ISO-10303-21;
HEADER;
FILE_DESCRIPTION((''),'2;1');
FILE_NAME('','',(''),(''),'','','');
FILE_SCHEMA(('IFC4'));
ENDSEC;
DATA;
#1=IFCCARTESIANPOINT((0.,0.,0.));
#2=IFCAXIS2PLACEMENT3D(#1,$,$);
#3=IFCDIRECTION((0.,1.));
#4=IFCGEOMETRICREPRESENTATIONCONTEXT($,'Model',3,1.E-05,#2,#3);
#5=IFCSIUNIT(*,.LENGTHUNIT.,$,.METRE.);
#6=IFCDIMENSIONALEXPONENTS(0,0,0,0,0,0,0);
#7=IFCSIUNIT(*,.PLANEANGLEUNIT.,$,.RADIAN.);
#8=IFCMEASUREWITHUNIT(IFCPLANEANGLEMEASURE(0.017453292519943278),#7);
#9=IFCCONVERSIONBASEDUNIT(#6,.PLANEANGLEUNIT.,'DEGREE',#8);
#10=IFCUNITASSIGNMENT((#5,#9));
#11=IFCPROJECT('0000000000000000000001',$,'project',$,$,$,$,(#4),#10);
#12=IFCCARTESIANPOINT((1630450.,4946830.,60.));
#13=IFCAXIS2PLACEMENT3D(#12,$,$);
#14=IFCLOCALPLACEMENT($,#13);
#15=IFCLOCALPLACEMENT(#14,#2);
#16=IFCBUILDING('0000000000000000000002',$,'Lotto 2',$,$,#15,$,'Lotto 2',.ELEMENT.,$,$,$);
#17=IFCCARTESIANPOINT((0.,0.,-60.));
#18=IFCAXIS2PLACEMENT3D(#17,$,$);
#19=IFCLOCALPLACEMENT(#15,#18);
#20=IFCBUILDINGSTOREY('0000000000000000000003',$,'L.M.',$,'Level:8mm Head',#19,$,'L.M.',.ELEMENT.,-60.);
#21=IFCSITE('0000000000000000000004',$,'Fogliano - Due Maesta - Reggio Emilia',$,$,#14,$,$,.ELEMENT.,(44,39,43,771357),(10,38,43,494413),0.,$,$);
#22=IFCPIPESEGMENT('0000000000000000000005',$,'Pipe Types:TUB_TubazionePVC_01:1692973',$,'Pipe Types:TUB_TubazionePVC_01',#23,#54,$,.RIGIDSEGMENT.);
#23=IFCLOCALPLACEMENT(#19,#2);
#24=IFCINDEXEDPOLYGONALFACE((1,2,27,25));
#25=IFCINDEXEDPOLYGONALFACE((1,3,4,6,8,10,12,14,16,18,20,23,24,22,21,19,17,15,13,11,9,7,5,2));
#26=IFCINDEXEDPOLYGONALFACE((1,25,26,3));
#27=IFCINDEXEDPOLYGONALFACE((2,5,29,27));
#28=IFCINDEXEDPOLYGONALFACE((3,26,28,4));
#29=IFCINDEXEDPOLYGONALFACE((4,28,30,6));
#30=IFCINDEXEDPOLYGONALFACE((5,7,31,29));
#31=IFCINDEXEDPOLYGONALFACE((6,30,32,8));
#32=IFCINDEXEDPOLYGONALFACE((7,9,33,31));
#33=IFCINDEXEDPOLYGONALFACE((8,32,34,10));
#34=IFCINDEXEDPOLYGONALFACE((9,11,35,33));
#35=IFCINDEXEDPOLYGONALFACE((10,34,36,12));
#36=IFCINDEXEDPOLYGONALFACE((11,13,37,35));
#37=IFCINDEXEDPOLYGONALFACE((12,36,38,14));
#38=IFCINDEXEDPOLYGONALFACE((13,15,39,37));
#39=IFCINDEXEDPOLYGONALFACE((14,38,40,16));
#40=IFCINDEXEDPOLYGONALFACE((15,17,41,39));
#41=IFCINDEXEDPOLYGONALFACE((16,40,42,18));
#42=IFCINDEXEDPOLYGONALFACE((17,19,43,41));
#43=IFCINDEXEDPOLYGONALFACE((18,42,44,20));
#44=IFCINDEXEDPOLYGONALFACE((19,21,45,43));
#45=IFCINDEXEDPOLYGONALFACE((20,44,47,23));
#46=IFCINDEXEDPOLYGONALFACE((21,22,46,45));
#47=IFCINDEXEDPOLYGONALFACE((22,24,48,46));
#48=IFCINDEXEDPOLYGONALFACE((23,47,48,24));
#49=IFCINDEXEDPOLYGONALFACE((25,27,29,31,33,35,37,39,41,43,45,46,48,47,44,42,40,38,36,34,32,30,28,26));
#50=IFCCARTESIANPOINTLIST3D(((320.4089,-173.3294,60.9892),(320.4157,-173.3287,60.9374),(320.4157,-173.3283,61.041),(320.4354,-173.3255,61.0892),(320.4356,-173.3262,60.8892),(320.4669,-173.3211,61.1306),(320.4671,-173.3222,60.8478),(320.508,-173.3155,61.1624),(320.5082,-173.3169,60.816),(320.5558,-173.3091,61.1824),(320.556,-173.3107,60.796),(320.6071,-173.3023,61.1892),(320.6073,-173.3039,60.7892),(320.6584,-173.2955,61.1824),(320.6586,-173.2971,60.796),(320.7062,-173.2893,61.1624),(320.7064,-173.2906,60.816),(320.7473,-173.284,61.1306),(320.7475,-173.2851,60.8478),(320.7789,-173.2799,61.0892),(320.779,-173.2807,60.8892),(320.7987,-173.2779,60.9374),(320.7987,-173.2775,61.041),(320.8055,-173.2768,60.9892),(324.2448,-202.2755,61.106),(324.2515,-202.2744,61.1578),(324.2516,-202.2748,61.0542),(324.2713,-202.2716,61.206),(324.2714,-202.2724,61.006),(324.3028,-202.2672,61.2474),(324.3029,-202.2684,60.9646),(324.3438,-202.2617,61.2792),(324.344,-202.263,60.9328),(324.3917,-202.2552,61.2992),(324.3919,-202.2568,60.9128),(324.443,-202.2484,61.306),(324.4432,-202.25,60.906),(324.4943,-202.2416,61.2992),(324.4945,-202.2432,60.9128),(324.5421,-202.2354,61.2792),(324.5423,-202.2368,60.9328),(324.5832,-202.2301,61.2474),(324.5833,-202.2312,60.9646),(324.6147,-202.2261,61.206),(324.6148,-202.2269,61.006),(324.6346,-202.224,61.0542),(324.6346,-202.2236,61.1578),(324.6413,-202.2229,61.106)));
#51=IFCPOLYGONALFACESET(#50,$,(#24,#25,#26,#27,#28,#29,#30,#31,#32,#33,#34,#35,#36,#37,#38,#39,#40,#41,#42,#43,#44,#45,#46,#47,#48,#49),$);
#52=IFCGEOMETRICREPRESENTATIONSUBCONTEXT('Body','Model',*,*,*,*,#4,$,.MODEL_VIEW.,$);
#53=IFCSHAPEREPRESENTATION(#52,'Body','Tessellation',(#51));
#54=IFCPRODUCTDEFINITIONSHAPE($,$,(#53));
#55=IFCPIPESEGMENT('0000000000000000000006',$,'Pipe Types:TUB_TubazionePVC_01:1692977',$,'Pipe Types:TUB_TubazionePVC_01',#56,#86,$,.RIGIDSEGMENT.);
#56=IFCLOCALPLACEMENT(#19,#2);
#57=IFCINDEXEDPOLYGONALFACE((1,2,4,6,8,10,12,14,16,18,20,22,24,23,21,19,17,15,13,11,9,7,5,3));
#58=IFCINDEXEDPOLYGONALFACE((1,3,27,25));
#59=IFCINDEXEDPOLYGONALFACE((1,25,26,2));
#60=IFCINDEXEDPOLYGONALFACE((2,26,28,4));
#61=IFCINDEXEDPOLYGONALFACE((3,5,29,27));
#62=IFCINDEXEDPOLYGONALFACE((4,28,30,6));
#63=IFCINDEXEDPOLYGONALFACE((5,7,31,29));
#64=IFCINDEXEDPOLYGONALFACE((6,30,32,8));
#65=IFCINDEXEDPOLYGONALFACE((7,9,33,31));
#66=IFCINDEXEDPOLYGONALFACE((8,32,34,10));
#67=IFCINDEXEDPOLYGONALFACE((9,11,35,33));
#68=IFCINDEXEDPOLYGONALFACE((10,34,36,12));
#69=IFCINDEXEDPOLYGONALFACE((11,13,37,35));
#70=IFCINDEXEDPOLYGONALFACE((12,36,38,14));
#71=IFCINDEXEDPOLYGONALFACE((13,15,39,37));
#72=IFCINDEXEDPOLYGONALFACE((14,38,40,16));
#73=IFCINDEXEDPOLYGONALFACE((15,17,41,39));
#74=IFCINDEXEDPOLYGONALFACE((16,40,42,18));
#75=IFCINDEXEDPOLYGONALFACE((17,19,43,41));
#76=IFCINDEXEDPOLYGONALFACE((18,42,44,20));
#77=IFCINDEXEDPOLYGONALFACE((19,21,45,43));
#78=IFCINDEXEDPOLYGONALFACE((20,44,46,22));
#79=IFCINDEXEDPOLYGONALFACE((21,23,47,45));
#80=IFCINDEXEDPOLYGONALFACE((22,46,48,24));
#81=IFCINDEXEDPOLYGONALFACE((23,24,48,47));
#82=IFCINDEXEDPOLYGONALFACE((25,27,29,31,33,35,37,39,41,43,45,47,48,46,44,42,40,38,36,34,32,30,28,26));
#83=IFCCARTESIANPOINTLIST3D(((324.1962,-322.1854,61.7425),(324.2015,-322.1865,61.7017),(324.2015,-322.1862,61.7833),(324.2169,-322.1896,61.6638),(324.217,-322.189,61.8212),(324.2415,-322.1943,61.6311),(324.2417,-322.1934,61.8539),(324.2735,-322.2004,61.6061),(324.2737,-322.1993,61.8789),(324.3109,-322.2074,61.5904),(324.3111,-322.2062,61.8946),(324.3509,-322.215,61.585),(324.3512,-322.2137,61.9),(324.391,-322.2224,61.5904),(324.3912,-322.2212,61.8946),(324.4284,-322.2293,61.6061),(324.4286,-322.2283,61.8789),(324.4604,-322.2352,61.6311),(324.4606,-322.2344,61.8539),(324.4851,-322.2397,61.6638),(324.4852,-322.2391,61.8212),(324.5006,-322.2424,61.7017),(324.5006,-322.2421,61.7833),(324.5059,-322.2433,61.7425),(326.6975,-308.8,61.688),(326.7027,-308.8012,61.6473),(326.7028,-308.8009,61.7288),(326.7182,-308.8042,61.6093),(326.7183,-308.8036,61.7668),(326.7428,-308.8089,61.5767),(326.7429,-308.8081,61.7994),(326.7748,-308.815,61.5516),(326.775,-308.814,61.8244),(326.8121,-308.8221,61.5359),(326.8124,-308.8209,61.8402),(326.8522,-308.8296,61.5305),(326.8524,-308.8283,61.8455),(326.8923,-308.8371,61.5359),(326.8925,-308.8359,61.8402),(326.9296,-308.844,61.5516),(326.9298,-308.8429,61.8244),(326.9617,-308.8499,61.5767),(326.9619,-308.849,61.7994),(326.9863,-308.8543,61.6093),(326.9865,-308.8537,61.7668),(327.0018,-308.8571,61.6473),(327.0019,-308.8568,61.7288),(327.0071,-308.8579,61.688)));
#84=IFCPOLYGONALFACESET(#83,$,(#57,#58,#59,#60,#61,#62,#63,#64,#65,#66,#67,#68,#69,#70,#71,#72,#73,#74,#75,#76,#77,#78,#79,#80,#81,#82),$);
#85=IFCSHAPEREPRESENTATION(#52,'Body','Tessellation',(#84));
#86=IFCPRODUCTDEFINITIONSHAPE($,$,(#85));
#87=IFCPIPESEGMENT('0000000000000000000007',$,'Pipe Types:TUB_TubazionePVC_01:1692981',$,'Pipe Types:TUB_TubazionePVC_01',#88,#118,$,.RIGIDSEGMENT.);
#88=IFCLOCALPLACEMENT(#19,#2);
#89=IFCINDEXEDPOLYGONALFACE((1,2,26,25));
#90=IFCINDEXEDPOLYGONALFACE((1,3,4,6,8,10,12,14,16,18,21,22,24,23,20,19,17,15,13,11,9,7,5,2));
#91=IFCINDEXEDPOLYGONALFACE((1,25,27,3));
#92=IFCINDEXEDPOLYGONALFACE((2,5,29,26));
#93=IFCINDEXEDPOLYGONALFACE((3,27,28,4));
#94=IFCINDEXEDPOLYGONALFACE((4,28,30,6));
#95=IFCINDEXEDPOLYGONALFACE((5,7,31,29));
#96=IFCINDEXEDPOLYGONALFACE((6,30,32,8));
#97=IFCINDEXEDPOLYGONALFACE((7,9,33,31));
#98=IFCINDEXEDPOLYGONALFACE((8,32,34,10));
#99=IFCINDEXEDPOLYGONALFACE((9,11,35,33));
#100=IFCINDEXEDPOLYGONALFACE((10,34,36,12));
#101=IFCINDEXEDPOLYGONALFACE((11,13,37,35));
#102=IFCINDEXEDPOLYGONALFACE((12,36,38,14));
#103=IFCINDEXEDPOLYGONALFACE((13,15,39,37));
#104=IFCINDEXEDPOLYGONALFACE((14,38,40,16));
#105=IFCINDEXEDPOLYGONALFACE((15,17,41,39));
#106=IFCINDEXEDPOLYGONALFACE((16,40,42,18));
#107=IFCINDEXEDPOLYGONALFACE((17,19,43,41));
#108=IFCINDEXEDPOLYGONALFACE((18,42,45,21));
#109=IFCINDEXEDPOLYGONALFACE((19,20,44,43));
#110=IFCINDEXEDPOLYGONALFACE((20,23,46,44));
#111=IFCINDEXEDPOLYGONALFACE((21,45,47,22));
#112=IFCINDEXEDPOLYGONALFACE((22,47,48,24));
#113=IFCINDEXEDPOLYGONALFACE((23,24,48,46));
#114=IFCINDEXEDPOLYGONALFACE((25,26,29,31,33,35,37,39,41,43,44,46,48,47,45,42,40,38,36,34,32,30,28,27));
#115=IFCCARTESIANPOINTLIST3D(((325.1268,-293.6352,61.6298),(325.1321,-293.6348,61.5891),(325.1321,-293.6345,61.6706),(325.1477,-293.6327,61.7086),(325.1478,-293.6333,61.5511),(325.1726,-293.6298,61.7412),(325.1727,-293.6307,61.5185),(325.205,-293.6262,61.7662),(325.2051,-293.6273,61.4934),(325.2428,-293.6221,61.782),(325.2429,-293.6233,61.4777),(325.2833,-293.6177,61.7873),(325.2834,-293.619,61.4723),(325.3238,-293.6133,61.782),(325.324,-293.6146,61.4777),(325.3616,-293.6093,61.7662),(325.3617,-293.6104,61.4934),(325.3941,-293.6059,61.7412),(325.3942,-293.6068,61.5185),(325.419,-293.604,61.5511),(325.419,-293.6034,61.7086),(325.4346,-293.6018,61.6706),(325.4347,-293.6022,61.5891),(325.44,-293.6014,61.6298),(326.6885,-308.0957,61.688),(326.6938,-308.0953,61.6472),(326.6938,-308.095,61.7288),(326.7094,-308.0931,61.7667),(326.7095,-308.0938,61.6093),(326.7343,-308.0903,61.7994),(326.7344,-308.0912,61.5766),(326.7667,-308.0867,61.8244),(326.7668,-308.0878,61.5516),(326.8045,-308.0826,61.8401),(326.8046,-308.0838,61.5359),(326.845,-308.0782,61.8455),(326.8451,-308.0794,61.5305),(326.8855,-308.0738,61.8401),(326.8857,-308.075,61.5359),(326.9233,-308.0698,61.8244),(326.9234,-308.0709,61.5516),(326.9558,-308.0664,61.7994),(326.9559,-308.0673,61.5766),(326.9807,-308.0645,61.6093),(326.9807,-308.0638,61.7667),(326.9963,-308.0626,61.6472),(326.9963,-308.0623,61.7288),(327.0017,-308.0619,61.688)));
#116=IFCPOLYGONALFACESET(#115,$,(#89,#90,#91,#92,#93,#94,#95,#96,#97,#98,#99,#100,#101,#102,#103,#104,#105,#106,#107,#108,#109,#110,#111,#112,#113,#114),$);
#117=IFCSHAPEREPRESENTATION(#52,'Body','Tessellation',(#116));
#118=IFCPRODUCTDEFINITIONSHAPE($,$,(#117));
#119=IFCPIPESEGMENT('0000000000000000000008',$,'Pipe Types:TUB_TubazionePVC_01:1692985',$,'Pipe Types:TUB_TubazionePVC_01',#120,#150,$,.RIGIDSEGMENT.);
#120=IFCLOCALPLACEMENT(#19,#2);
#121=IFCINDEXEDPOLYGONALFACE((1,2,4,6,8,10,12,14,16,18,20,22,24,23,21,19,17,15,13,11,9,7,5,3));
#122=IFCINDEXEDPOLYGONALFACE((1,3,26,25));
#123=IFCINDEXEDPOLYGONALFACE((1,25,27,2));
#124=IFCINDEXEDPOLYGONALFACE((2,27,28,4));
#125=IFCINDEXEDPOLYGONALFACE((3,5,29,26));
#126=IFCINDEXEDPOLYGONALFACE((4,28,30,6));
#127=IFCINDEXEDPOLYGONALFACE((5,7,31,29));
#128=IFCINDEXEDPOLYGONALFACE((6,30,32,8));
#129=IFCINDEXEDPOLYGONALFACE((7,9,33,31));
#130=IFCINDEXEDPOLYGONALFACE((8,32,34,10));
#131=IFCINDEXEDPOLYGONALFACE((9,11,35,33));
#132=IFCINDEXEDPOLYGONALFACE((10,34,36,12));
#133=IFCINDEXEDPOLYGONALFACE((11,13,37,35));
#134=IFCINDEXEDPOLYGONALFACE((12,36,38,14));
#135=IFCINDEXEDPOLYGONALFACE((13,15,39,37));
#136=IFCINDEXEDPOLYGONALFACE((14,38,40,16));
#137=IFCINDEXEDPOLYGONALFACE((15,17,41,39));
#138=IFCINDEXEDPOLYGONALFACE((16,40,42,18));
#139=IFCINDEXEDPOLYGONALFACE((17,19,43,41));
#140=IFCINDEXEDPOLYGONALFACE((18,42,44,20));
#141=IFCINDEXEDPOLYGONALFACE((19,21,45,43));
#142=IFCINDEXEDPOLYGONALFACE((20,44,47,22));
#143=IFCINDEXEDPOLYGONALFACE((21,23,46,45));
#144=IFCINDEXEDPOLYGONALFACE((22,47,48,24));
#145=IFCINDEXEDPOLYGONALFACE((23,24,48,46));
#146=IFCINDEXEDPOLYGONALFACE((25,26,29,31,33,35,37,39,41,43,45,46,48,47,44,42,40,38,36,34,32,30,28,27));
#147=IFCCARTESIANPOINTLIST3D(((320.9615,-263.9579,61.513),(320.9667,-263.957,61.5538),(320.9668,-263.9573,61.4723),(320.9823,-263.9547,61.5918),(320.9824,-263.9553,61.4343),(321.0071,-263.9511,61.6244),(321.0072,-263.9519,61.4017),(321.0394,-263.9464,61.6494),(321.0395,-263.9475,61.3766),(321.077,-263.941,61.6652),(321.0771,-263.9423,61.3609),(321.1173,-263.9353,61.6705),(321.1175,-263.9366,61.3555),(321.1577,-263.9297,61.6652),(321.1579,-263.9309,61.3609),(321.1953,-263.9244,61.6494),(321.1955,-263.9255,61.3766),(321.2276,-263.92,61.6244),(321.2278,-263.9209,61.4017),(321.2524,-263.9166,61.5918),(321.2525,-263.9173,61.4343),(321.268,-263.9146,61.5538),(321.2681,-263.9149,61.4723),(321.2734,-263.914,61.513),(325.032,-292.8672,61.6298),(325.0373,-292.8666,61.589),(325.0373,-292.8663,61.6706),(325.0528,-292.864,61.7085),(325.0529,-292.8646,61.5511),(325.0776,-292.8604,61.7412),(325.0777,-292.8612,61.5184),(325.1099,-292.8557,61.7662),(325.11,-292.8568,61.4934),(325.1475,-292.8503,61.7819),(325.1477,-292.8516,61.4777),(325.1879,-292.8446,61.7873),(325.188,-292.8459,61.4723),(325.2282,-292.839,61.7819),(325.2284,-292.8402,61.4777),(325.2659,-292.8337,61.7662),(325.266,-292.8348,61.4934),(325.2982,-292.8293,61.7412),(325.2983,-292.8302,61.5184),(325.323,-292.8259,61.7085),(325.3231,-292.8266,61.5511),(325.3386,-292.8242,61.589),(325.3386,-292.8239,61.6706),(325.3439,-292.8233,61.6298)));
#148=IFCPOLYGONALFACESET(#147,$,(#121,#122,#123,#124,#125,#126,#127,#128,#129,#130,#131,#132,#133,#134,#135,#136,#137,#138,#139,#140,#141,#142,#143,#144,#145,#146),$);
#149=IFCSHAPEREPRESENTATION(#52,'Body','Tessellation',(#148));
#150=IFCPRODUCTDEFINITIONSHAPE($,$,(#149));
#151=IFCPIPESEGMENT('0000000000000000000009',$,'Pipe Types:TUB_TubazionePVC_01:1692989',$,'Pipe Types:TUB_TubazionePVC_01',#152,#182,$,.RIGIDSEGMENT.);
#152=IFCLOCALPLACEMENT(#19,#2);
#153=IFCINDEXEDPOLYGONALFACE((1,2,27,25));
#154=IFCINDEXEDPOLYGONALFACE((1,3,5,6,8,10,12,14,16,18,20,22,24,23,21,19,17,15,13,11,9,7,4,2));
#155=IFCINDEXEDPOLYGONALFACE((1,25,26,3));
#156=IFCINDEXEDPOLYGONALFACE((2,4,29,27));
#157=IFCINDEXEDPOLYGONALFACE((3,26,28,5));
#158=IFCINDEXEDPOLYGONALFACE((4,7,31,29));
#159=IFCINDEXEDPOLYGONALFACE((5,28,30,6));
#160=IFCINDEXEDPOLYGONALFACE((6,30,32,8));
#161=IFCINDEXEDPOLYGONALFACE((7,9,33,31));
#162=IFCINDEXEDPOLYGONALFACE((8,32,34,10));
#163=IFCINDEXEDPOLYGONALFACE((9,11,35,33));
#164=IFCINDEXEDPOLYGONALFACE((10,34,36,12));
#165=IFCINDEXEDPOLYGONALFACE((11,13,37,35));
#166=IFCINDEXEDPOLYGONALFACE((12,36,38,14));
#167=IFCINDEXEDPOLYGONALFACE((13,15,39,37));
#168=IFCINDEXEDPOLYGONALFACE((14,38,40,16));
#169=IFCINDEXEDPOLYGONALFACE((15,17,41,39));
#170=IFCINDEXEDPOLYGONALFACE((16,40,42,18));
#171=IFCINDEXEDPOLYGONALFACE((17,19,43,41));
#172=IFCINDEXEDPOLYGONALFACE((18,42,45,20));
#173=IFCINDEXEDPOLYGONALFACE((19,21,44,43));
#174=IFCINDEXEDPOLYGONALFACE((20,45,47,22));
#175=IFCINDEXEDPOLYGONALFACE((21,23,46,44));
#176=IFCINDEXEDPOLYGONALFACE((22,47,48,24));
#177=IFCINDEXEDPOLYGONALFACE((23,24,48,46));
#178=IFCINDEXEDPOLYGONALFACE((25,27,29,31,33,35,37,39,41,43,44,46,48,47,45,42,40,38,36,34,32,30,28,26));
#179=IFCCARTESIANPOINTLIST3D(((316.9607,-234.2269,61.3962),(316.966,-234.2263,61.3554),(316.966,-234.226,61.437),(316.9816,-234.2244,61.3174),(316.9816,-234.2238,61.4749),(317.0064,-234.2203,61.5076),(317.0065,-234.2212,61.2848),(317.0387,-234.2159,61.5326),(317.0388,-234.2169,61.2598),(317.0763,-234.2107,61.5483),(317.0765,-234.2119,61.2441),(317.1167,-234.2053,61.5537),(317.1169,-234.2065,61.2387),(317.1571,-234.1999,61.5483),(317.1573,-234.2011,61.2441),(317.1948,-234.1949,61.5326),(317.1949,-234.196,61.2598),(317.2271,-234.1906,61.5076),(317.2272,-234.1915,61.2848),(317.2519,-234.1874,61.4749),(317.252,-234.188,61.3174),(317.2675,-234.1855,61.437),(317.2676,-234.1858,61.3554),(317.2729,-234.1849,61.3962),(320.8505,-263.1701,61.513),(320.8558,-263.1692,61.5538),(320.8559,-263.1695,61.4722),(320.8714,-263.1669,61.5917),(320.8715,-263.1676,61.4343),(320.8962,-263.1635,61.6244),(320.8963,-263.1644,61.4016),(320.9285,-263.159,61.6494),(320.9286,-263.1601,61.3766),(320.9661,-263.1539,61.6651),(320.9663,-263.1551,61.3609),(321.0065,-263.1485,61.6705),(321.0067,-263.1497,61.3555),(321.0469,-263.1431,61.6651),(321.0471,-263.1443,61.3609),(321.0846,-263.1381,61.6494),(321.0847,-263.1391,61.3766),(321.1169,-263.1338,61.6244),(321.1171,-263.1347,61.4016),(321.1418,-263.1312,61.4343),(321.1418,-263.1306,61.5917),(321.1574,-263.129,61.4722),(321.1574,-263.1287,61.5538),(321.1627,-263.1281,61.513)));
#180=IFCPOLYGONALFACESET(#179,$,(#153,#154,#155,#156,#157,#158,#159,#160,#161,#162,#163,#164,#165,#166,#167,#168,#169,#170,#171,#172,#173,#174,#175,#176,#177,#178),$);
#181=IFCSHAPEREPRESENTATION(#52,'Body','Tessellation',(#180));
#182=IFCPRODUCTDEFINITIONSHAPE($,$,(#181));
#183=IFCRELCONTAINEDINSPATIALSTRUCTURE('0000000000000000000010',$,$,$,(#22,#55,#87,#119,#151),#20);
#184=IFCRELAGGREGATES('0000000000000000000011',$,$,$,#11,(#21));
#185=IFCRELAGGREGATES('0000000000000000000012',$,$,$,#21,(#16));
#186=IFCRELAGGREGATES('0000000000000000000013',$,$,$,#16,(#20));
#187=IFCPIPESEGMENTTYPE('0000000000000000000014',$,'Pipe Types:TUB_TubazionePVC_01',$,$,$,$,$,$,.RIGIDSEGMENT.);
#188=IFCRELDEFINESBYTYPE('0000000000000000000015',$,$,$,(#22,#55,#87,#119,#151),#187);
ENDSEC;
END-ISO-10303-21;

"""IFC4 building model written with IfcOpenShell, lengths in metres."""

from ifc_helpers import new_model, entity, si_unit, converted_unit, direction, frame, origin, place, context, subcontext, project, spatial, arc, indexed_curve, outline, extrude, type_object, element, save


model = new_model("IFC4")

# Units and contexts
model_context = context("Model", 3, precision=1e-05, world=origin(), true_north=direction((0.0, 1.0)))
body_context = subcontext(model_context, "Body", "Model", "MODEL_VIEW")
ifc_project = project(units=[si_unit("LENGTHUNIT", "METRE"), converted_unit("PLANEANGLEUNIT", "DEGREE", entity("IfcPlaneAngleMeasure", 0.017453292519943278), si_unit("PLANEANGLEUNIT", "RADIAN"), dimensions=[0, 0, 0, 0, 0, 0, 0])], contexts=[model_context])

# Site, building, storey
site_placement = place(None, frame((1630450.0, 4946830.0, 60.0)))
site = spatial("IfcSite", under=ifc_project, at=site_placement, Name="Fogliano - Due Maesta - Reggio Emilia", CompositionType="ELEMENT", RefLatitude=(44, 39, 43, 771357), RefLongitude=(10, 38, 43, 494413), RefElevation=0.0)
building_placement = place(site_placement, origin())
building = spatial("IfcBuilding", under=site, at=building_placement, Name="Lotto 2", LongName="Lotto 2", CompositionType="ELEMENT")
storey_placement = place(building_placement, frame((0.0, 0.0, -60.0)))
storey = spatial("IfcBuildingStorey", under=building, at=storey_placement, Name="L.M.", ObjectType="Level:8mm Head", LongName="L.M.", CompositionType="ELEMENT", Elevation=-60.0)

# Pipe segments
pipe_segment_type = type_object("IfcPipeSegmentType", Name="Pipe Types:TUB_TubazionePVC_01", PredefinedType="RIGIDSEGMENT")
pipe_segment_1_placement = place(storey_placement, origin())
element("IfcPipeSegment", 1, at=pipe_segment_1_placement, inside=storey, type_object=pipe_segment_type, Name="Pipe Types:TUB_TubazionePVC_01:1692973", ObjectType="Pipe Types:TUB_TubazionePVC_01", PredefinedType="RIGIDSEGMENT", context=body_context, shape_type="SweptSolid", body=[
    extrude(outline(indexed_curve([(0.2, 0.0), (0.1414, 0.1414), (0.0, 0.2), (-0.1414, 0.1414), (-0.2, 0.0), (-0.1414, -0.1414), (0.0, -0.2), (0.1414, -0.1414)], segments=[arc(1, 2, 3), arc(3, 4, 5), arc(5, 6, 7), arc(7, 8, 1)], self_intersect=False)), frame((320.6072, -173.3031, 60.9892), z_axis=(0.131368, -0.991326, 0.004), x_axis=(0.991334, 0.131369, 0.0)), (0.0, 0.0, 1.0), 29.1994),
])
pipe_segment_2_placement = place(storey_placement, origin())
element("IfcPipeSegment", 2, at=pipe_segment_2_placement, inside=storey, type_object=pipe_segment_type, Name="Pipe Types:TUB_TubazionePVC_01:1692977", ObjectType="Pipe Types:TUB_TubazionePVC_01", PredefinedType="RIGIDSEGMENT", context=body_context, shape_type="SweptSolid", body=[
    extrude(outline(indexed_curve([(0.1575, 0.0), (0.1114, 0.1114), (0.0, 0.1575), (-0.1114, 0.1114), (-0.1575, 0.0), (-0.1114, -0.1114), (0.0, -0.1575), (0.1114, -0.1114)], segments=[arc(1, 2, 3), arc(3, 4, 5), arc(5, 6, 7), arc(7, 8, 1)], self_intersect=False)), frame((324.3511, -322.2143, 61.7425), z_axis=(0.183685, 0.982977, -0.004), x_axis=(0.982985, -0.183687, 0.0)), (0.0, 0.0, 1.0), 13.6172),
])
pipe_segment_3_placement = place(storey_placement, origin())
element("IfcPipeSegment", 3, at=pipe_segment_3_placement, inside=storey, type_object=pipe_segment_type, Name="Pipe Types:TUB_TubazionePVC_01:1692981", ObjectType="Pipe Types:TUB_TubazionePVC_01", PredefinedType="RIGIDSEGMENT", context=body_context, shape_type="SweptSolid", body=[
    extrude(outline(indexed_curve([(0.1575, 0.0), (0.1114, 0.1114), (0.0, 0.1575), (-0.1114, 0.1114), (-0.1575, 0.0), (-0.1114, -0.1114), (0.0, -0.1575), (0.1114, -0.1114)], segments=[arc(1, 2, 3), arc(3, 4, 5), arc(5, 6, 7), arc(7, 8, 1)], self_intersect=False)), frame((326.8451, -308.0788, 61.688), z_axis=(-0.107373, 0.994211, -0.004), x_axis=(0.994219, 0.107373, 0.0)), (0.0, 0.0, 1.0), 14.5447),
])
pipe_segment_4_placement = place(storey_placement, origin())
element("IfcPipeSegment", 4, at=pipe_segment_4_placement, inside=storey, type_object=pipe_segment_type, Name="Pipe Types:TUB_TubazionePVC_01:1692985", ObjectType="Pipe Types:TUB_TubazionePVC_01", PredefinedType="RIGIDSEGMENT", context=body_context, shape_type="SweptSolid", body=[
    extrude(outline(indexed_curve([(0.1575, 0.0), (0.1114, 0.1114), (0.0, 0.1575), (-0.1114, 0.1114), (-0.1575, 0.0), (-0.1114, -0.1114), (0.0, -0.1575), (0.1114, -0.1114)], segments=[arc(1, 2, 3), arc(3, 4, 5), arc(5, 6, 7), arc(7, 8, 1)], self_intersect=False)), frame((325.188, -292.8453, 61.6298), z_axis=(-0.139427, 0.990224, -0.004), x_axis=(0.990232, 0.139428, 0.0)), (0.0, 0.0, 1.0), 29.1947),
])
pipe_segment_5_placement = place(storey_placement, origin())
element("IfcPipeSegment", 5, at=pipe_segment_5_placement, inside=storey, type_object=pipe_segment_type, Name="Pipe Types:TUB_TubazionePVC_01:1692989", ObjectType="Pipe Types:TUB_TubazionePVC_01", PredefinedType="RIGIDSEGMENT", context=body_context, shape_type="SweptSolid", body=[
    extrude(outline(indexed_curve([(0.1575, 0.0), (0.1114, 0.1114), (0.0, 0.1575), (-0.1114, 0.1114), (-0.1575, 0.0), (-0.1114, -0.1114), (0.0, -0.1575), (0.1114, -0.1114)], segments=[arc(1, 2, 3), arc(3, 4, 5), arc(5, 6, 7), arc(7, 8, 1)], self_intersect=False)), frame((321.0066, -263.1491, 61.513), z_axis=(-0.133197, 0.991082, -0.004), x_axis=(0.991089, 0.133198, 0.0)), (0.0, 0.0, 1.0), 29.2036),
])

save(model, "model.ifc")
